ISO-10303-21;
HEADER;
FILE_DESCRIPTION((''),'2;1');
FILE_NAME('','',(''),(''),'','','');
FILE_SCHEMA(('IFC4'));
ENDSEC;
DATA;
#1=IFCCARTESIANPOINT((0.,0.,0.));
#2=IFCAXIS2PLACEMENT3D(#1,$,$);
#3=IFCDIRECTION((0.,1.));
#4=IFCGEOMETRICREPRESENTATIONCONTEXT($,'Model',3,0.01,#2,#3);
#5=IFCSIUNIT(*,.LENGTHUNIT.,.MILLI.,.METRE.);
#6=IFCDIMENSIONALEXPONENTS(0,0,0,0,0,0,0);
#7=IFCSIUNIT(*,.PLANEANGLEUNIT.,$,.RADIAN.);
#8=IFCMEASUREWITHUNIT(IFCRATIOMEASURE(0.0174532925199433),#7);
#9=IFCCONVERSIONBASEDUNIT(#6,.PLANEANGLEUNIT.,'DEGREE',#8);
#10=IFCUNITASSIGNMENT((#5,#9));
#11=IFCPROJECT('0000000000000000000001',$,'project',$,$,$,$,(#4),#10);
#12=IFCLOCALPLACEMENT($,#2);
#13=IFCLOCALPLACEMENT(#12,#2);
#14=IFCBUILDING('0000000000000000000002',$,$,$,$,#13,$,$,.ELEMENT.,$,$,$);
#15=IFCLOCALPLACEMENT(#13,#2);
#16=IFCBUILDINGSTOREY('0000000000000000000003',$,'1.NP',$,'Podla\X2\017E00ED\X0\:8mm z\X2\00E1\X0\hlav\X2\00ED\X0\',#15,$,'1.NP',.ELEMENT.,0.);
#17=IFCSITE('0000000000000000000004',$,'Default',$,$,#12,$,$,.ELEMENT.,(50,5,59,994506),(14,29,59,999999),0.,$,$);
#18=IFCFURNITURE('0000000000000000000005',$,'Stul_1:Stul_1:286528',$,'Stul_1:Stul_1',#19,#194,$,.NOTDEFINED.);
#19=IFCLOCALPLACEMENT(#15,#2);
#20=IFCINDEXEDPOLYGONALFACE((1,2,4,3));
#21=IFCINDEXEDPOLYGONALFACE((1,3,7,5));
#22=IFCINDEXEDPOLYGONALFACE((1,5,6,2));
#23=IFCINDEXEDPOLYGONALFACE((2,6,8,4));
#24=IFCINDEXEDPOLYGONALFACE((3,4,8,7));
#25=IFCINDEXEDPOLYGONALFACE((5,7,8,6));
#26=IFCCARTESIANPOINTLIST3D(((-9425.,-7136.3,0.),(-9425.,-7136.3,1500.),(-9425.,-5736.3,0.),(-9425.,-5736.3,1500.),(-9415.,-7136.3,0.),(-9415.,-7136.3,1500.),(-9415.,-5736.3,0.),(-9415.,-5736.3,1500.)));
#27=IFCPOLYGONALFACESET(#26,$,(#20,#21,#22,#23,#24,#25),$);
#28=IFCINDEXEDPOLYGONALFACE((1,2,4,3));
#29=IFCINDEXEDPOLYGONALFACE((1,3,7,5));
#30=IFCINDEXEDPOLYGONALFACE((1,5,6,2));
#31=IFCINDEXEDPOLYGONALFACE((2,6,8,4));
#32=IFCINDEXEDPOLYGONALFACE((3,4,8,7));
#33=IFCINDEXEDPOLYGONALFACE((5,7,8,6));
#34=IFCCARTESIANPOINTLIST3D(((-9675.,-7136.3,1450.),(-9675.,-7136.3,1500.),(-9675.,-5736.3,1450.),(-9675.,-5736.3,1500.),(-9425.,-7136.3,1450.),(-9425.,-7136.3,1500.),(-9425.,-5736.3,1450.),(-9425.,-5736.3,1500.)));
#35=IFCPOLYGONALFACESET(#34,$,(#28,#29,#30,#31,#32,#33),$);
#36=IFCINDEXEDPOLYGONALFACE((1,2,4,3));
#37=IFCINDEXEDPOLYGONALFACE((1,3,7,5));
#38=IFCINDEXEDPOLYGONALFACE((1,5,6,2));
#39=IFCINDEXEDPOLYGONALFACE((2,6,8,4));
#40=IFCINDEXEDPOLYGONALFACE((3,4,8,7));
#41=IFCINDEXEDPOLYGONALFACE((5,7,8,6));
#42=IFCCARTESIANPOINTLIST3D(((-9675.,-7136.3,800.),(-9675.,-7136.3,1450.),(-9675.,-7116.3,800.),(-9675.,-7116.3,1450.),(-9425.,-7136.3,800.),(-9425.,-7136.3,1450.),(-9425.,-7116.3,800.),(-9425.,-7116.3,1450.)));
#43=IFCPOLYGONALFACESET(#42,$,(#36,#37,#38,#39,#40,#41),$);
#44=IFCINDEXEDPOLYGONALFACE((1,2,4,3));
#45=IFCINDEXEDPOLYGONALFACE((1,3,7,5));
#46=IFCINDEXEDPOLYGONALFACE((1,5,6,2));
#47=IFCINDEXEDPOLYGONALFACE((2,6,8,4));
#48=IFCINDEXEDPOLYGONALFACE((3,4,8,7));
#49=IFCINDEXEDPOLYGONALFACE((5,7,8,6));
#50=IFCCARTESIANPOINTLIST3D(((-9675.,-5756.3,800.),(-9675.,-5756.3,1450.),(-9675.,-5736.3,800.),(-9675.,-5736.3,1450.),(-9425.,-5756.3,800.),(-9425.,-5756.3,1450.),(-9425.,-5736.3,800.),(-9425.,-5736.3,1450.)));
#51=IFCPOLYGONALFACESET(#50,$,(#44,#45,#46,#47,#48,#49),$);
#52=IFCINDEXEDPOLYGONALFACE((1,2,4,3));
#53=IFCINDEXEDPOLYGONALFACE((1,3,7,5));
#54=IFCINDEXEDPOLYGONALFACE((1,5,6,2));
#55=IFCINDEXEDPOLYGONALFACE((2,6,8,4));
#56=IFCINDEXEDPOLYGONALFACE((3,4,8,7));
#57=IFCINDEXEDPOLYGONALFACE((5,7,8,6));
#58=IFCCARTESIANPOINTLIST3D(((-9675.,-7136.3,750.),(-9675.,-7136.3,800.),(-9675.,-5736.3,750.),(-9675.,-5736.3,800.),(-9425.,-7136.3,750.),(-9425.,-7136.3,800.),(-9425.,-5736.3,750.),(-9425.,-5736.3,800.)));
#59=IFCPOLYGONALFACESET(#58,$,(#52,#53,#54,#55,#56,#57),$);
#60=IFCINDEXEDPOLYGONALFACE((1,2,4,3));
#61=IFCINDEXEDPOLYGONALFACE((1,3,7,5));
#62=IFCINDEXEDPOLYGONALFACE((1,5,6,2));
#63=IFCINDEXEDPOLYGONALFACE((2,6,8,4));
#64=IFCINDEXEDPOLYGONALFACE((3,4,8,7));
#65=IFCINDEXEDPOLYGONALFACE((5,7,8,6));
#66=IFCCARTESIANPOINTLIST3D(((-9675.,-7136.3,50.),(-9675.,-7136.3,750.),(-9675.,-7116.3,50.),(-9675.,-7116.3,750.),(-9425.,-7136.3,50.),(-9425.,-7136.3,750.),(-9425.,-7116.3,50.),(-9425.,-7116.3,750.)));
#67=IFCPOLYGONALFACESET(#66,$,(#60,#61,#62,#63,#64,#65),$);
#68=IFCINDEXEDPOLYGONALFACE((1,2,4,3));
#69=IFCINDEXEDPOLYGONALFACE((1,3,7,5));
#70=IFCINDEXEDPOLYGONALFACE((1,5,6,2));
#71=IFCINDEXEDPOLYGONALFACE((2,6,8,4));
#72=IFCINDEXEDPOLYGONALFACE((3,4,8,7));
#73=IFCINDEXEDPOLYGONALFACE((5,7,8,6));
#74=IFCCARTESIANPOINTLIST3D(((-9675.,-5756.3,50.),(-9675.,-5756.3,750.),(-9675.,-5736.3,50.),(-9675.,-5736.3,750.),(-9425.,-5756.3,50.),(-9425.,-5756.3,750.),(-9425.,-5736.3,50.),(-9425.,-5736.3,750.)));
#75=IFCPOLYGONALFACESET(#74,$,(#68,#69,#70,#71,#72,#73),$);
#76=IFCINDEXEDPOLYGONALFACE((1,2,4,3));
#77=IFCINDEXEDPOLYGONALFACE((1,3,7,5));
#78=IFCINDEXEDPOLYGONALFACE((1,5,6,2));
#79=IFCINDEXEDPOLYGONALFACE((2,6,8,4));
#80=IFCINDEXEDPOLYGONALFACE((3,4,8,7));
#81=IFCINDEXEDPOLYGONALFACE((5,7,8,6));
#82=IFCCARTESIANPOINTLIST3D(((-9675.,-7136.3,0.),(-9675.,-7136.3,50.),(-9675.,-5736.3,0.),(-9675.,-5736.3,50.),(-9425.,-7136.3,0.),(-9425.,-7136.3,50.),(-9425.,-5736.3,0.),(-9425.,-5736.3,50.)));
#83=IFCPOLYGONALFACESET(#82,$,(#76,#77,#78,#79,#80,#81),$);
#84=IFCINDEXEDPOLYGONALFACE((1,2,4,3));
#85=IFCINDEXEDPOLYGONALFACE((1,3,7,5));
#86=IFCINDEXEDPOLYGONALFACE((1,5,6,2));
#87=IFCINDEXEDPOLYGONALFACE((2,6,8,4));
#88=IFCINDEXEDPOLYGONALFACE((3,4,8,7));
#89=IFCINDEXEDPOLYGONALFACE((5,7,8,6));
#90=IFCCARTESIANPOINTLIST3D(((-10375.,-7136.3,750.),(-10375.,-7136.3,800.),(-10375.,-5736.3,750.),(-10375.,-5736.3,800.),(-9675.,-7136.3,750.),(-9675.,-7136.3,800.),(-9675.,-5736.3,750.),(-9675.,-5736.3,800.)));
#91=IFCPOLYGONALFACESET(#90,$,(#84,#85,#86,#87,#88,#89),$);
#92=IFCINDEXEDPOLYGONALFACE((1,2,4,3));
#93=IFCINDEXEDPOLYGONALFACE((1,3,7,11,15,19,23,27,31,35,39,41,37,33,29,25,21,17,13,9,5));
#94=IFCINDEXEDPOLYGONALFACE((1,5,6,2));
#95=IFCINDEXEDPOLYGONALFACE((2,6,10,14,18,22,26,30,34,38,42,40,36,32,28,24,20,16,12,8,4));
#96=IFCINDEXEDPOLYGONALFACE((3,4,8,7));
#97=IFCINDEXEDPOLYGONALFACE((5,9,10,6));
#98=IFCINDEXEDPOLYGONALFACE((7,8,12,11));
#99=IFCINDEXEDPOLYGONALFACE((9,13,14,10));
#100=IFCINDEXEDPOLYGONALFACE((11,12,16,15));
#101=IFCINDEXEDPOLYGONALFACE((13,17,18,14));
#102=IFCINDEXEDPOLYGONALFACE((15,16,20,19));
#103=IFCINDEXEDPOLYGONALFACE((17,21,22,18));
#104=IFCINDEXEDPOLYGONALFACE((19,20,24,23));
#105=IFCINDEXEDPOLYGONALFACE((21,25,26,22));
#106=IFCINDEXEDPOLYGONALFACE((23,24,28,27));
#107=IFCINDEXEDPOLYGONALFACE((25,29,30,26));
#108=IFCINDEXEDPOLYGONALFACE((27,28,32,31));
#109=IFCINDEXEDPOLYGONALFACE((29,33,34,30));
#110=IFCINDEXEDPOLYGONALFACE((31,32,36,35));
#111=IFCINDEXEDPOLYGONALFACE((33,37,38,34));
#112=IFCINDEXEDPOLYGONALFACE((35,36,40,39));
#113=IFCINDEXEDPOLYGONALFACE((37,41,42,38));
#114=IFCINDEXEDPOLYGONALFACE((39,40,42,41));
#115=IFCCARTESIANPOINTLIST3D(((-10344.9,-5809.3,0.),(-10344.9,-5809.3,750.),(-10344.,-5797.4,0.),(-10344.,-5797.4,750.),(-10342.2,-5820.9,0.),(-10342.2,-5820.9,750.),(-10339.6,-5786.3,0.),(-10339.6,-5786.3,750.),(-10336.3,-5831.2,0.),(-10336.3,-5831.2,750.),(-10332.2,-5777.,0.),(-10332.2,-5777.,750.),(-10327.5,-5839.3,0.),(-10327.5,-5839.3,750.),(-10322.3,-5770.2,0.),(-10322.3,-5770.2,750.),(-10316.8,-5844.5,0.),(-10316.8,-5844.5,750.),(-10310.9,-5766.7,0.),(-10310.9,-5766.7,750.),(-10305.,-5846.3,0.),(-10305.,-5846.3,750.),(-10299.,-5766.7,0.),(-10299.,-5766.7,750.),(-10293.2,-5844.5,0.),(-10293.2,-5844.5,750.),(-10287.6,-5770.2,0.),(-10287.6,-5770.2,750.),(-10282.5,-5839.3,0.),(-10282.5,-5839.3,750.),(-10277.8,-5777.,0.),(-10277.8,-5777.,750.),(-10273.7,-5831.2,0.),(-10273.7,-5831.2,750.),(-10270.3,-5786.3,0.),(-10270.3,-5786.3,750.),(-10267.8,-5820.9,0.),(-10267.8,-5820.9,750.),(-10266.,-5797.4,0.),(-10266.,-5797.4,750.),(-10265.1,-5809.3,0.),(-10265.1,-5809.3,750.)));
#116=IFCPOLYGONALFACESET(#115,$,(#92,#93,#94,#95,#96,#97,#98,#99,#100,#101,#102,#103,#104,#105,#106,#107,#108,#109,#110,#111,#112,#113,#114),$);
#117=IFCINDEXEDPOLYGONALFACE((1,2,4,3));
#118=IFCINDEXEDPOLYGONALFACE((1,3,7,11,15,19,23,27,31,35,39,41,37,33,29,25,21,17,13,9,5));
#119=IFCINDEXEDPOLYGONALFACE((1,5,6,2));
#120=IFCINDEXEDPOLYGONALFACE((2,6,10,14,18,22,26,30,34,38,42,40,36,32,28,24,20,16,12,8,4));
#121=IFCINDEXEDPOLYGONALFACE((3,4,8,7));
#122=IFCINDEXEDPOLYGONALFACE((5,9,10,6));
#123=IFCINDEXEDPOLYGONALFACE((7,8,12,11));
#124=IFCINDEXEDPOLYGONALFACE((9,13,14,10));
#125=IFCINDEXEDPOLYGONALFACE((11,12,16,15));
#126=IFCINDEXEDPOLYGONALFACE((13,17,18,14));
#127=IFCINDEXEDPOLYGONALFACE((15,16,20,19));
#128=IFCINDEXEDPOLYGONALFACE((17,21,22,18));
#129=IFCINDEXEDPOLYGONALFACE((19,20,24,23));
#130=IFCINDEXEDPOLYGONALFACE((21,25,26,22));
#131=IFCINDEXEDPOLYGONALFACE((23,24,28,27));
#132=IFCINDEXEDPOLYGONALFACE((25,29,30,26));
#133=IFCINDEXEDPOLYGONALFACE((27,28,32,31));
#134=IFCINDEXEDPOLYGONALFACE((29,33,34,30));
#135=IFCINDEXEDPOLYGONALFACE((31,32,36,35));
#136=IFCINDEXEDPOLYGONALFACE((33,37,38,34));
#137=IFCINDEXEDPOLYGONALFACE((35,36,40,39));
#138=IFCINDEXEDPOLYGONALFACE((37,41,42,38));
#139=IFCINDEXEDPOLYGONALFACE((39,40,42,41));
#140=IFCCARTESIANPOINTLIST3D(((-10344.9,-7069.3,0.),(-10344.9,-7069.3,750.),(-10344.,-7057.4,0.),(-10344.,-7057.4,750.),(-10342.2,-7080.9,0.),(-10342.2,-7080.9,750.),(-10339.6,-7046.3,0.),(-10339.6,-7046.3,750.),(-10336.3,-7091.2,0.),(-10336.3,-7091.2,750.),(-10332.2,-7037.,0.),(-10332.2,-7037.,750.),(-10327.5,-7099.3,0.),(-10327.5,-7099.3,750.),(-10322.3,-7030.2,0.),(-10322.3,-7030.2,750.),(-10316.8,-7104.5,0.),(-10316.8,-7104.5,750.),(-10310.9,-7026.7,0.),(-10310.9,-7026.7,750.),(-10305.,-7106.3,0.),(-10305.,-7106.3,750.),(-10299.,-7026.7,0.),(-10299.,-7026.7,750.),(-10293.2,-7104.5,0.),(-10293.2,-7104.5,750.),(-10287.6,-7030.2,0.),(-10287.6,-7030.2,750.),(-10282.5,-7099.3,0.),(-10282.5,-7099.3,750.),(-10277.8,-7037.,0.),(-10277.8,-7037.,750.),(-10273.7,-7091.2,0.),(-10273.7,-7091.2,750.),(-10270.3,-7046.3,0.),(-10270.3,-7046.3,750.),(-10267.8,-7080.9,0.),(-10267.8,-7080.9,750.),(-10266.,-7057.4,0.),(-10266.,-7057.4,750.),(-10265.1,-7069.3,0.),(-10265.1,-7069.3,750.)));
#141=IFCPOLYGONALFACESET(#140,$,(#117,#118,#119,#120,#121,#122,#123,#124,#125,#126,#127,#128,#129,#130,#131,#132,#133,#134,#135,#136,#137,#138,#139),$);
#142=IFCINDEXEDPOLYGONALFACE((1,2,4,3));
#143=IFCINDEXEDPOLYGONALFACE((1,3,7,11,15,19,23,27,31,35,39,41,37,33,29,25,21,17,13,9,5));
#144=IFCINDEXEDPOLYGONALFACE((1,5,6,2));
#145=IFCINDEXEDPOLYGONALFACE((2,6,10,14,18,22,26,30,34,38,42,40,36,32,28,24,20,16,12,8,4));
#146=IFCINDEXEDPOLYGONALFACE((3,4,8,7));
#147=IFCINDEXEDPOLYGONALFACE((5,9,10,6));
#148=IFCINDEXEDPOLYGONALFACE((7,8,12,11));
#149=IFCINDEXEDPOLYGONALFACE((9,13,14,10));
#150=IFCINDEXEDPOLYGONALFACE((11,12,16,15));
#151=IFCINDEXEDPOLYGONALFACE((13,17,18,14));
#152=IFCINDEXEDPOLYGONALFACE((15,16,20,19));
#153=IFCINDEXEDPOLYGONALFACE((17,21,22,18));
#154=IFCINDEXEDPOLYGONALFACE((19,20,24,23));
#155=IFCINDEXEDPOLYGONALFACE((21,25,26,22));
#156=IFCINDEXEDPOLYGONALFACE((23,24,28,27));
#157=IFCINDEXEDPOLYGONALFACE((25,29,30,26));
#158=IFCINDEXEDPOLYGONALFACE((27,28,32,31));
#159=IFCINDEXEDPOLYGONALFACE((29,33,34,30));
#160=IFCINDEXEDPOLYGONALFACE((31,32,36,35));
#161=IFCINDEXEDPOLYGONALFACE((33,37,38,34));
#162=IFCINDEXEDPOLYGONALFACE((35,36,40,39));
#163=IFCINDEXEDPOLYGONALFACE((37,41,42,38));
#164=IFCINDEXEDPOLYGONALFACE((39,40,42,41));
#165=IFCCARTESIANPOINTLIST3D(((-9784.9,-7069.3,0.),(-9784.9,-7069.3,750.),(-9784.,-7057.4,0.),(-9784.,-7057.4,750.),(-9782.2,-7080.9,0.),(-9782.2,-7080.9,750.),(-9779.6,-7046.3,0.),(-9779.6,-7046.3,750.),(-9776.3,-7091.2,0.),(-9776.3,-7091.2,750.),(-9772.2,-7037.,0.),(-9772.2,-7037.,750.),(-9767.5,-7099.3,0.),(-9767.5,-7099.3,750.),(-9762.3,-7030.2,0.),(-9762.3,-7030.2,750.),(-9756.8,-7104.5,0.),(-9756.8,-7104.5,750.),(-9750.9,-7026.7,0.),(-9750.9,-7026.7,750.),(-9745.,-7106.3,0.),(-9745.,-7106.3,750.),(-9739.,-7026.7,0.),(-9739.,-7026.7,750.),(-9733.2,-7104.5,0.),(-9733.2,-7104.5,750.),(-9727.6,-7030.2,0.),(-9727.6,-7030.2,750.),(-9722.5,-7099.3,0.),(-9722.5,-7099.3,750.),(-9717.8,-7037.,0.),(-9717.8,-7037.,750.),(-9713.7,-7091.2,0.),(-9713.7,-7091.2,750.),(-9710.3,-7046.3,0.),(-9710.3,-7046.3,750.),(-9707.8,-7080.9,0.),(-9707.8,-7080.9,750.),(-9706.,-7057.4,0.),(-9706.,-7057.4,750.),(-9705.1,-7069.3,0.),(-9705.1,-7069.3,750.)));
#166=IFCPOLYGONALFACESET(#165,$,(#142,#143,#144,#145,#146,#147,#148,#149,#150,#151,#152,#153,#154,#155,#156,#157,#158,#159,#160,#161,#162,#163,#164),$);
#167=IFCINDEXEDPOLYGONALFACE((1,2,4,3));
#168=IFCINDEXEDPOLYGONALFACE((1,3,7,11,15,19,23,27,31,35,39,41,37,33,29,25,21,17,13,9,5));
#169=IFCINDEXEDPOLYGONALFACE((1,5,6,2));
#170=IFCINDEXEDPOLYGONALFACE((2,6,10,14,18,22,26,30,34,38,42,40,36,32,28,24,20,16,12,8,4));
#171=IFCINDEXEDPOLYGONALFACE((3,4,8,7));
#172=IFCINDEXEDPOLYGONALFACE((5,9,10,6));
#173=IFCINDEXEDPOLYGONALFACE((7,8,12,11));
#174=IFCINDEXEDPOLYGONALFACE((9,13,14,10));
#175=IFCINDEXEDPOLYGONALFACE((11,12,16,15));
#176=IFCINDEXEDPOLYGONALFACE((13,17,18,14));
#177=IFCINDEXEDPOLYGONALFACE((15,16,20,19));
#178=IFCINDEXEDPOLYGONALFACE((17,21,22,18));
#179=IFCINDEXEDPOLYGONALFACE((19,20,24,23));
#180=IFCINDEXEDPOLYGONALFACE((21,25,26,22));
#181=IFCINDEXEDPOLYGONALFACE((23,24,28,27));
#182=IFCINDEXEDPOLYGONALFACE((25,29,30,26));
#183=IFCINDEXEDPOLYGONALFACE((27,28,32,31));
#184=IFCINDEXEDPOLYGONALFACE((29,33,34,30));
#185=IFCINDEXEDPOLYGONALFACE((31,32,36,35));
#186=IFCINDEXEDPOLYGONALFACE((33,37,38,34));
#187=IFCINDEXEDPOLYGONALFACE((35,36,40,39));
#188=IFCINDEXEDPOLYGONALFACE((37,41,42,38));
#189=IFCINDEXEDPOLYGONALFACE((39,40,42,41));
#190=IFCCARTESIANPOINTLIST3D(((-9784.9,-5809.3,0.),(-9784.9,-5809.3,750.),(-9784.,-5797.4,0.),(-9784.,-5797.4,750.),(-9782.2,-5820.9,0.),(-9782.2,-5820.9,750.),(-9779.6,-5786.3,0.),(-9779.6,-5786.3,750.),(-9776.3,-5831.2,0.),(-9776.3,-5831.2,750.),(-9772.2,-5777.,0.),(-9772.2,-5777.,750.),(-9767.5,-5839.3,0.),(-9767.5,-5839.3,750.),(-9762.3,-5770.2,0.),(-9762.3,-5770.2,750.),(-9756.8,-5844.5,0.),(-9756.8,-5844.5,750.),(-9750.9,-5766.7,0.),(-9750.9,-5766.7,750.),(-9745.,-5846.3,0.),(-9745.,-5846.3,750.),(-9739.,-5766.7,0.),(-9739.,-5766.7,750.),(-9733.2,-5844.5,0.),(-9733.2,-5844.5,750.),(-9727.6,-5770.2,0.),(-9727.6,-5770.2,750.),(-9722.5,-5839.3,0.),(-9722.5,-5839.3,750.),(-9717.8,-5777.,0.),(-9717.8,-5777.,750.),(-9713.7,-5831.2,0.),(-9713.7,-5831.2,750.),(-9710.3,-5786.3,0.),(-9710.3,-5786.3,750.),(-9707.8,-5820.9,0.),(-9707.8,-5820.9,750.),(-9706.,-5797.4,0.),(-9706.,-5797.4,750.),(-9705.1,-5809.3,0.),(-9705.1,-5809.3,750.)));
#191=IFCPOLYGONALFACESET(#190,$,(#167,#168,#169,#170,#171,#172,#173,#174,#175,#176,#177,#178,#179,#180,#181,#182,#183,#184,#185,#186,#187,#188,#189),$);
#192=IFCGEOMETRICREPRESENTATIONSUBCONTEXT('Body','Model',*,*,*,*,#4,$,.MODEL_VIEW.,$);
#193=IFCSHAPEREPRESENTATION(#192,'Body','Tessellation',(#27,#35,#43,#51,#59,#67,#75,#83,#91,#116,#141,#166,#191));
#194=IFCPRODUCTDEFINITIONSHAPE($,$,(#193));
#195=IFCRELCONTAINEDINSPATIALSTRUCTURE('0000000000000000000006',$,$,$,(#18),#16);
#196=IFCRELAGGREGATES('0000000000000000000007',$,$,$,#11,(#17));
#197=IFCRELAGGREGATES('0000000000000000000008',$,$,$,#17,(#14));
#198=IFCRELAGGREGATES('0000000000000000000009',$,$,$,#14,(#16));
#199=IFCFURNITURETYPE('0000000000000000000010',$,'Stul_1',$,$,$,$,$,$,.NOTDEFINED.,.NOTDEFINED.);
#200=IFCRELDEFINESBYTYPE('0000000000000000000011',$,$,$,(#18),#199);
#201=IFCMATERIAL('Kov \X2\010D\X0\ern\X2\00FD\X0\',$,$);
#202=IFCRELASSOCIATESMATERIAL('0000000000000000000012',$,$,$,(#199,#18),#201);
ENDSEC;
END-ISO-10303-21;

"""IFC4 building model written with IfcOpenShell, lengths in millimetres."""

from ifc_helpers import new_model, entity, si_unit, converted_unit, direction, frame, frame_2d, origin, origin_2d_with_axis, place, context, subcontext, project, spatial, rectangle, circle, extrude, source, transform, mapped, material, type_object, type_shapes, element, save


model = new_model("IFC4")

# Units and contexts
model_context = context("Model", 3, precision=0.01, world=origin(), true_north=direction((0.0, 1.0)))
body_context = subcontext(model_context, "Body", "Model", "MODEL_VIEW")
ifc_project = project(units=[si_unit("LENGTHUNIT", "METRE", prefix="MILLI"), converted_unit("PLANEANGLEUNIT", "DEGREE", entity("IfcRatioMeasure", 0.0174532925199433), si_unit("PLANEANGLEUNIT", "RADIAN"), dimensions=[0, 0, 0, 0, 0, 0, 0])], contexts=[model_context])

# Site, building, storey
site_placement = place(None, origin())
site = spatial("IfcSite", under=ifc_project, at=site_placement, Name="Default", CompositionType="ELEMENT", RefLatitude=(50, 5, 59, 994506), RefLongitude=(14, 29, 59, 999999), RefElevation=0.0)
building_placement = place(site_placement, origin())
building = spatial("IfcBuilding", under=site, at=building_placement, CompositionType="ELEMENT")
storey_placement = place(building_placement, origin())
storey = spatial("IfcBuildingStorey", under=building, at=storey_placement, Name="1.NP", ObjectType="Podlaží:8mm záhlaví", LongName="1.NP", CompositionType="ELEMENT", Elevation=0.0)

# Furniture
ifc_material_1 = material(Name="Kov černý")
furniture_type = type_object("IfcFurnitureType", Name="Stul_1", AssemblyPlace="NOTDEFINED", PredefinedType="NOTDEFINED", material=ifc_material_1)
shared_shape_1 = source(origin(), body_context, "Body", "SweptSolid", [
    extrude(rectangle(XDim=1400.0, YDim=10.0, at=origin_2d_with_axis()), frame((0.0, 605.0, 0.0), z_axis=(0.0, 0.0, 1.0), x_axis=(-1.0, 0.0, 0.0)), (0.0, 0.0, 1.0), 1500.0),
    extrude(rectangle(XDim=1400.0, YDim=250.0, at=frame_2d((0.0, 0.0), x_axis=(1.0, 0.0))), frame((0.0, 475.0, 1450.0), z_axis=(0.0, 0.0, 1.0), x_axis=(-1.0, 0.0, 0.0)), (0.0, 0.0, 1.0), 50.0),
    extrude(rectangle(XDim=20.0, YDim=250.0, at=origin_2d_with_axis()), frame((690.0, 475.0, 800.0), z_axis=(0.0, 0.0, 1.0), x_axis=(-1.0, 0.0, 0.0)), (0.0, 0.0, 1.0), 650.0),
    extrude(rectangle(XDim=20.0, YDim=250.0, at=frame_2d((0.0, 0.0), x_axis=(1.0, 0.0))), frame((-690.0, 475.0, 800.0), z_axis=(0.0, 0.0, 1.0), x_axis=(-1.0, 0.0, 0.0)), (0.0, 0.0, 1.0), 650.0),
    extrude(rectangle(XDim=1400.0, YDim=250.0, at=origin_2d_with_axis()), frame((0.0, 475.0, 750.0), z_axis=(0.0, 0.0, 1.0), x_axis=(-1.0, 0.0, 0.0)), (0.0, 0.0, 1.0), 50.0),
    extrude(rectangle(XDim=20.0, YDim=250.0, at=origin_2d_with_axis()), frame((690.0, 475.0, 50.0), z_axis=(0.0, 0.0, 1.0), x_axis=(-1.0, 0.0, 0.0)), (0.0, 0.0, 1.0), 700.0),
    extrude(rectangle(XDim=20.0, YDim=250.0, at=frame_2d((0.0, 0.0), x_axis=(1.0, 0.0))), frame((-690.0, 475.0, 50.0), z_axis=(0.0, 0.0, 1.0), x_axis=(-1.0, 0.0, 0.0)), (0.0, 0.0, 1.0), 700.0),
    extrude(rectangle(XDim=1400.0, YDim=250.0, at=origin_2d_with_axis()), frame((0.0, 475.0, 0.0), z_axis=(0.0, 0.0, 1.0), x_axis=(-1.0, 0.0, 0.0)), (0.0, 0.0, 1.0), 50.0),
    extrude(rectangle(XDim=1400.0, YDim=700.0, at=origin_2d_with_axis()), frame((0.0, 0.0, 750.0), z_axis=(0.0, 0.0, 1.0), x_axis=(-1.0, 0.0, 0.0)), (0.0, 0.0, 1.0), 50.0),
    extrude(circle(Radius=40.0, at=frame_2d((0.0, 0.0), x_axis=(1.0, 0.0))), frame((-630.0, -280.0, 0.0)), (0.0, 0.0, 1.0), 750.0),
    extrude(circle(Radius=40.0, at=frame_2d((0.0, 0.0), x_axis=(1.0, 0.0))), frame((630.0, -280.0, 0.0)), (0.0, 0.0, 1.0), 750.0),
    extrude(circle(Radius=40.0, at=frame_2d((0.0, 0.0), x_axis=(1.0, 0.0))), frame((630.0, 280.0, 0.0)), (0.0, 0.0, 1.0), 750.0),
    extrude(circle(Radius=40.0, at=frame_2d((0.0, 0.0), x_axis=(1.0, 0.0))), frame((-630.0, 280.0, 0.0)), (0.0, 0.0, 1.0), 750.0),
])
type_shapes(furniture_type, [shared_shape_1])
for number, where, z_axis, x_axis, name in (
    (1, (-10025.0, -6436.3, 0.0), (0.0, 0.0, 1.0), (0.0, -1.0, 0.0), "Stul_1:Stul_1:286528"),
):
    element("IfcFurniture", number, at=place(storey_placement, frame(where, z_axis=z_axis, x_axis=x_axis)), inside=storey, type_object=furniture_type, material=ifc_material_1, Name=name, ObjectType="Stul_1:Stul_1", PredefinedType="NOTDEFINED", context=body_context, shape_type="MappedRepresentation", body=[
        mapped(shared_shape_1, transform((0.0, 0.0, 0.0), scale=1.0)),
    ])

save(model, "model.ifc")
